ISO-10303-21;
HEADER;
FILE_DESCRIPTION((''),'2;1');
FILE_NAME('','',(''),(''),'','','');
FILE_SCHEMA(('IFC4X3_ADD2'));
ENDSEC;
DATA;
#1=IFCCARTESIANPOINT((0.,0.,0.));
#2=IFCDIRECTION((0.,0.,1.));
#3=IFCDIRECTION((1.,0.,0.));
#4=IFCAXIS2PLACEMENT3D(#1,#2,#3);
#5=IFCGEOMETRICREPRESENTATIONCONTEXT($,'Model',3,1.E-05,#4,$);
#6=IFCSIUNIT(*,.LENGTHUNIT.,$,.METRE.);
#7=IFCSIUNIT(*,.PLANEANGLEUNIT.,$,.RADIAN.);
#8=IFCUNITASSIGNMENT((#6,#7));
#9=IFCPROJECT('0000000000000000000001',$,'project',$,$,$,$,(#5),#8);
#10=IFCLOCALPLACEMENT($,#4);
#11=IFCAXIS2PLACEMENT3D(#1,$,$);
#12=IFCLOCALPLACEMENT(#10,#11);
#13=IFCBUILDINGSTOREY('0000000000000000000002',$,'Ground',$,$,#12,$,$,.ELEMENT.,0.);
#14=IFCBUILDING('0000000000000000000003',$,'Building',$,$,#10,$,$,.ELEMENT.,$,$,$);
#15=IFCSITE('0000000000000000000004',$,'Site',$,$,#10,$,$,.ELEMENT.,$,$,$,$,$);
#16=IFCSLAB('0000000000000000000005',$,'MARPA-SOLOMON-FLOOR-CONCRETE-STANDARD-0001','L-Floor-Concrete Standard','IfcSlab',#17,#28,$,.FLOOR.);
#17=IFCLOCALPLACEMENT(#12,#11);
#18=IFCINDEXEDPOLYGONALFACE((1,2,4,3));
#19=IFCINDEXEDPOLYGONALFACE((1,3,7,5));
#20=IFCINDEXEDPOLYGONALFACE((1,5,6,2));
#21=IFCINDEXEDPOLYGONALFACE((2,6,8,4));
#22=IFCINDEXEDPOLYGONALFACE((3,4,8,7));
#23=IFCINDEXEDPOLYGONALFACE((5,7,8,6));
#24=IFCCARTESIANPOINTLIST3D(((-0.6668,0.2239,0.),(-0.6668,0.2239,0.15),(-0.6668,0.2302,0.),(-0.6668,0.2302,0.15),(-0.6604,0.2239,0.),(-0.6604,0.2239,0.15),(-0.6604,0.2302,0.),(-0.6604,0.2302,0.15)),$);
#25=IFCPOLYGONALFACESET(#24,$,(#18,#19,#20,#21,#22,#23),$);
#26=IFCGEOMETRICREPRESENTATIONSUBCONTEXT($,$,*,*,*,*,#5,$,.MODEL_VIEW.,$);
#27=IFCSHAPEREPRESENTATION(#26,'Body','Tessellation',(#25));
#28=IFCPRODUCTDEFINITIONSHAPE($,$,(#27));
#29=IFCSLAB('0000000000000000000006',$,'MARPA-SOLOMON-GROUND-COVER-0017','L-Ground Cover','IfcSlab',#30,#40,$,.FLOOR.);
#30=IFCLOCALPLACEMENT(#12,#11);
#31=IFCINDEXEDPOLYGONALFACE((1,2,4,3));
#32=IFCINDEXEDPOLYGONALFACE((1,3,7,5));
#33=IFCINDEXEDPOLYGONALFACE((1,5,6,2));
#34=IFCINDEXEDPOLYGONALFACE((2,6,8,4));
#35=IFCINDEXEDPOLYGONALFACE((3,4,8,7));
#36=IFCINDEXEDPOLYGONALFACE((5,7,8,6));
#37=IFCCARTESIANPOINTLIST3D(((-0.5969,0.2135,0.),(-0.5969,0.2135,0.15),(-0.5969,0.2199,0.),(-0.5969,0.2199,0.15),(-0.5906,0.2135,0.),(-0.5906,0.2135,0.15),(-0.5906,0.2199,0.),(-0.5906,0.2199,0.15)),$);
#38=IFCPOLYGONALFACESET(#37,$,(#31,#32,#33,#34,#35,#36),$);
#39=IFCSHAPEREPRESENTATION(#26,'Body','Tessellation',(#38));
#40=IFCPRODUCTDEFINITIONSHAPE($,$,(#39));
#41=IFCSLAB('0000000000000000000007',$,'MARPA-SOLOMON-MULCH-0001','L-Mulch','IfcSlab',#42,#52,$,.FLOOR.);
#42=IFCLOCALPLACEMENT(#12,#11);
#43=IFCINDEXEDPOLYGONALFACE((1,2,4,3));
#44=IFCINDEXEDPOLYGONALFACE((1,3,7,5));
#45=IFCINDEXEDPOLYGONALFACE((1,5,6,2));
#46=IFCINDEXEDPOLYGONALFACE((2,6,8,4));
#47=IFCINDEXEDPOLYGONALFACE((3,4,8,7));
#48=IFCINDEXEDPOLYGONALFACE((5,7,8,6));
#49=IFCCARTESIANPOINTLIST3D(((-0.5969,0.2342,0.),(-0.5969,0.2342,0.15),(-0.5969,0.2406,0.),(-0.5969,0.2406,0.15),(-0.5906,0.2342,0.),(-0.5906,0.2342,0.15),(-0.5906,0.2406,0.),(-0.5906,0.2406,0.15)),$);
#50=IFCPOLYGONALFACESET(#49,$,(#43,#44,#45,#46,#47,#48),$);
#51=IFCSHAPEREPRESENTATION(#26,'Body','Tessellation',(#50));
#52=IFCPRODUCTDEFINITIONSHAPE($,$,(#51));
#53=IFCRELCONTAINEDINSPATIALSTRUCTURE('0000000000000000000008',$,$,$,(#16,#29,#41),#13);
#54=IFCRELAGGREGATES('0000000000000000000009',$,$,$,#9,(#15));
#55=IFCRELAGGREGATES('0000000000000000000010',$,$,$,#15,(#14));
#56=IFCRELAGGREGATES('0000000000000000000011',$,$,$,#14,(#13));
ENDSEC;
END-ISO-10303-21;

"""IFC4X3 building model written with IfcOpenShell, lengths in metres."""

from ifc_helpers import new_model, si_unit, frame, origin, origin_with_axes, place, context, subcontext, project, spatial, polyline, outline, extrude, element, save


model = new_model("IFC4X3")

# Units and contexts
model_context = context("Model", 3, precision=1e-05, world=origin_with_axes())
sub_context = subcontext(model_context, None, None, "MODEL_VIEW")
ifc_project = project(units=[si_unit("LENGTHUNIT", "METRE"), si_unit("PLANEANGLEUNIT", "RADIAN")], contexts=[model_context])

# Site, building, storey
placement = place(None, origin_with_axes())
site = spatial("IfcSite", under=ifc_project, at=placement, Name="Site", CompositionType="ELEMENT")
building = spatial("IfcBuilding", under=site, at=placement, Name="Building", CompositionType="ELEMENT")
storey_placement = place(placement, origin())
storey = spatial("IfcBuildingStorey", under=building, at=storey_placement, Name="Ground", CompositionType="ELEMENT", Elevation=0.0)

# Slabs
for number, where, name in (
    (1, (-0.6668, 0.2239, 0.0), "MARPA-SOLOMON-FLOOR-CONCRETE-STANDARD-0001"),
):
    element("IfcSlab", number, at=place(storey_placement, frame(where)), inside=storey, Name=name, Description="L-Floor-Concrete Standard", ObjectType="IfcSlab", PredefinedType="FLOOR", context=sub_context, shape_type="SweptSolid", body=[
        extrude(outline(polyline([(0.0, 0.0063), (0.0063, 0.0063), (0.0063, 0.0), (0.0, 0.0), (0.0, 0.0063)])), origin(), (0.0, 0.0, 1.0), 0.15),
    ])
for number, where, name, description in (
    (2, (-0.5969, 0.2135, 0.0), "MARPA-SOLOMON-GROUND-COVER-0017", "L-Ground Cover"),
    (3, (-0.5969, 0.2342, 0.0), "MARPA-SOLOMON-MULCH-0001", "L-Mulch"),
):
    element("IfcSlab", number, at=place(storey_placement, frame(where)), inside=storey, Name=name, Description=description, ObjectType="IfcSlab", PredefinedType="FLOOR", context=sub_context, shape_type="SweptSolid", body=[
        extrude(outline(polyline([(0.0, 0.0063), (0.0063, 0.0063), (0.0063, 0.0), (0.0, 0.0), (0.0, 0.0063)])), origin(), (0.0, 0.0, 1.0), 0.15),
    ])

save(model, "model.ifc")
